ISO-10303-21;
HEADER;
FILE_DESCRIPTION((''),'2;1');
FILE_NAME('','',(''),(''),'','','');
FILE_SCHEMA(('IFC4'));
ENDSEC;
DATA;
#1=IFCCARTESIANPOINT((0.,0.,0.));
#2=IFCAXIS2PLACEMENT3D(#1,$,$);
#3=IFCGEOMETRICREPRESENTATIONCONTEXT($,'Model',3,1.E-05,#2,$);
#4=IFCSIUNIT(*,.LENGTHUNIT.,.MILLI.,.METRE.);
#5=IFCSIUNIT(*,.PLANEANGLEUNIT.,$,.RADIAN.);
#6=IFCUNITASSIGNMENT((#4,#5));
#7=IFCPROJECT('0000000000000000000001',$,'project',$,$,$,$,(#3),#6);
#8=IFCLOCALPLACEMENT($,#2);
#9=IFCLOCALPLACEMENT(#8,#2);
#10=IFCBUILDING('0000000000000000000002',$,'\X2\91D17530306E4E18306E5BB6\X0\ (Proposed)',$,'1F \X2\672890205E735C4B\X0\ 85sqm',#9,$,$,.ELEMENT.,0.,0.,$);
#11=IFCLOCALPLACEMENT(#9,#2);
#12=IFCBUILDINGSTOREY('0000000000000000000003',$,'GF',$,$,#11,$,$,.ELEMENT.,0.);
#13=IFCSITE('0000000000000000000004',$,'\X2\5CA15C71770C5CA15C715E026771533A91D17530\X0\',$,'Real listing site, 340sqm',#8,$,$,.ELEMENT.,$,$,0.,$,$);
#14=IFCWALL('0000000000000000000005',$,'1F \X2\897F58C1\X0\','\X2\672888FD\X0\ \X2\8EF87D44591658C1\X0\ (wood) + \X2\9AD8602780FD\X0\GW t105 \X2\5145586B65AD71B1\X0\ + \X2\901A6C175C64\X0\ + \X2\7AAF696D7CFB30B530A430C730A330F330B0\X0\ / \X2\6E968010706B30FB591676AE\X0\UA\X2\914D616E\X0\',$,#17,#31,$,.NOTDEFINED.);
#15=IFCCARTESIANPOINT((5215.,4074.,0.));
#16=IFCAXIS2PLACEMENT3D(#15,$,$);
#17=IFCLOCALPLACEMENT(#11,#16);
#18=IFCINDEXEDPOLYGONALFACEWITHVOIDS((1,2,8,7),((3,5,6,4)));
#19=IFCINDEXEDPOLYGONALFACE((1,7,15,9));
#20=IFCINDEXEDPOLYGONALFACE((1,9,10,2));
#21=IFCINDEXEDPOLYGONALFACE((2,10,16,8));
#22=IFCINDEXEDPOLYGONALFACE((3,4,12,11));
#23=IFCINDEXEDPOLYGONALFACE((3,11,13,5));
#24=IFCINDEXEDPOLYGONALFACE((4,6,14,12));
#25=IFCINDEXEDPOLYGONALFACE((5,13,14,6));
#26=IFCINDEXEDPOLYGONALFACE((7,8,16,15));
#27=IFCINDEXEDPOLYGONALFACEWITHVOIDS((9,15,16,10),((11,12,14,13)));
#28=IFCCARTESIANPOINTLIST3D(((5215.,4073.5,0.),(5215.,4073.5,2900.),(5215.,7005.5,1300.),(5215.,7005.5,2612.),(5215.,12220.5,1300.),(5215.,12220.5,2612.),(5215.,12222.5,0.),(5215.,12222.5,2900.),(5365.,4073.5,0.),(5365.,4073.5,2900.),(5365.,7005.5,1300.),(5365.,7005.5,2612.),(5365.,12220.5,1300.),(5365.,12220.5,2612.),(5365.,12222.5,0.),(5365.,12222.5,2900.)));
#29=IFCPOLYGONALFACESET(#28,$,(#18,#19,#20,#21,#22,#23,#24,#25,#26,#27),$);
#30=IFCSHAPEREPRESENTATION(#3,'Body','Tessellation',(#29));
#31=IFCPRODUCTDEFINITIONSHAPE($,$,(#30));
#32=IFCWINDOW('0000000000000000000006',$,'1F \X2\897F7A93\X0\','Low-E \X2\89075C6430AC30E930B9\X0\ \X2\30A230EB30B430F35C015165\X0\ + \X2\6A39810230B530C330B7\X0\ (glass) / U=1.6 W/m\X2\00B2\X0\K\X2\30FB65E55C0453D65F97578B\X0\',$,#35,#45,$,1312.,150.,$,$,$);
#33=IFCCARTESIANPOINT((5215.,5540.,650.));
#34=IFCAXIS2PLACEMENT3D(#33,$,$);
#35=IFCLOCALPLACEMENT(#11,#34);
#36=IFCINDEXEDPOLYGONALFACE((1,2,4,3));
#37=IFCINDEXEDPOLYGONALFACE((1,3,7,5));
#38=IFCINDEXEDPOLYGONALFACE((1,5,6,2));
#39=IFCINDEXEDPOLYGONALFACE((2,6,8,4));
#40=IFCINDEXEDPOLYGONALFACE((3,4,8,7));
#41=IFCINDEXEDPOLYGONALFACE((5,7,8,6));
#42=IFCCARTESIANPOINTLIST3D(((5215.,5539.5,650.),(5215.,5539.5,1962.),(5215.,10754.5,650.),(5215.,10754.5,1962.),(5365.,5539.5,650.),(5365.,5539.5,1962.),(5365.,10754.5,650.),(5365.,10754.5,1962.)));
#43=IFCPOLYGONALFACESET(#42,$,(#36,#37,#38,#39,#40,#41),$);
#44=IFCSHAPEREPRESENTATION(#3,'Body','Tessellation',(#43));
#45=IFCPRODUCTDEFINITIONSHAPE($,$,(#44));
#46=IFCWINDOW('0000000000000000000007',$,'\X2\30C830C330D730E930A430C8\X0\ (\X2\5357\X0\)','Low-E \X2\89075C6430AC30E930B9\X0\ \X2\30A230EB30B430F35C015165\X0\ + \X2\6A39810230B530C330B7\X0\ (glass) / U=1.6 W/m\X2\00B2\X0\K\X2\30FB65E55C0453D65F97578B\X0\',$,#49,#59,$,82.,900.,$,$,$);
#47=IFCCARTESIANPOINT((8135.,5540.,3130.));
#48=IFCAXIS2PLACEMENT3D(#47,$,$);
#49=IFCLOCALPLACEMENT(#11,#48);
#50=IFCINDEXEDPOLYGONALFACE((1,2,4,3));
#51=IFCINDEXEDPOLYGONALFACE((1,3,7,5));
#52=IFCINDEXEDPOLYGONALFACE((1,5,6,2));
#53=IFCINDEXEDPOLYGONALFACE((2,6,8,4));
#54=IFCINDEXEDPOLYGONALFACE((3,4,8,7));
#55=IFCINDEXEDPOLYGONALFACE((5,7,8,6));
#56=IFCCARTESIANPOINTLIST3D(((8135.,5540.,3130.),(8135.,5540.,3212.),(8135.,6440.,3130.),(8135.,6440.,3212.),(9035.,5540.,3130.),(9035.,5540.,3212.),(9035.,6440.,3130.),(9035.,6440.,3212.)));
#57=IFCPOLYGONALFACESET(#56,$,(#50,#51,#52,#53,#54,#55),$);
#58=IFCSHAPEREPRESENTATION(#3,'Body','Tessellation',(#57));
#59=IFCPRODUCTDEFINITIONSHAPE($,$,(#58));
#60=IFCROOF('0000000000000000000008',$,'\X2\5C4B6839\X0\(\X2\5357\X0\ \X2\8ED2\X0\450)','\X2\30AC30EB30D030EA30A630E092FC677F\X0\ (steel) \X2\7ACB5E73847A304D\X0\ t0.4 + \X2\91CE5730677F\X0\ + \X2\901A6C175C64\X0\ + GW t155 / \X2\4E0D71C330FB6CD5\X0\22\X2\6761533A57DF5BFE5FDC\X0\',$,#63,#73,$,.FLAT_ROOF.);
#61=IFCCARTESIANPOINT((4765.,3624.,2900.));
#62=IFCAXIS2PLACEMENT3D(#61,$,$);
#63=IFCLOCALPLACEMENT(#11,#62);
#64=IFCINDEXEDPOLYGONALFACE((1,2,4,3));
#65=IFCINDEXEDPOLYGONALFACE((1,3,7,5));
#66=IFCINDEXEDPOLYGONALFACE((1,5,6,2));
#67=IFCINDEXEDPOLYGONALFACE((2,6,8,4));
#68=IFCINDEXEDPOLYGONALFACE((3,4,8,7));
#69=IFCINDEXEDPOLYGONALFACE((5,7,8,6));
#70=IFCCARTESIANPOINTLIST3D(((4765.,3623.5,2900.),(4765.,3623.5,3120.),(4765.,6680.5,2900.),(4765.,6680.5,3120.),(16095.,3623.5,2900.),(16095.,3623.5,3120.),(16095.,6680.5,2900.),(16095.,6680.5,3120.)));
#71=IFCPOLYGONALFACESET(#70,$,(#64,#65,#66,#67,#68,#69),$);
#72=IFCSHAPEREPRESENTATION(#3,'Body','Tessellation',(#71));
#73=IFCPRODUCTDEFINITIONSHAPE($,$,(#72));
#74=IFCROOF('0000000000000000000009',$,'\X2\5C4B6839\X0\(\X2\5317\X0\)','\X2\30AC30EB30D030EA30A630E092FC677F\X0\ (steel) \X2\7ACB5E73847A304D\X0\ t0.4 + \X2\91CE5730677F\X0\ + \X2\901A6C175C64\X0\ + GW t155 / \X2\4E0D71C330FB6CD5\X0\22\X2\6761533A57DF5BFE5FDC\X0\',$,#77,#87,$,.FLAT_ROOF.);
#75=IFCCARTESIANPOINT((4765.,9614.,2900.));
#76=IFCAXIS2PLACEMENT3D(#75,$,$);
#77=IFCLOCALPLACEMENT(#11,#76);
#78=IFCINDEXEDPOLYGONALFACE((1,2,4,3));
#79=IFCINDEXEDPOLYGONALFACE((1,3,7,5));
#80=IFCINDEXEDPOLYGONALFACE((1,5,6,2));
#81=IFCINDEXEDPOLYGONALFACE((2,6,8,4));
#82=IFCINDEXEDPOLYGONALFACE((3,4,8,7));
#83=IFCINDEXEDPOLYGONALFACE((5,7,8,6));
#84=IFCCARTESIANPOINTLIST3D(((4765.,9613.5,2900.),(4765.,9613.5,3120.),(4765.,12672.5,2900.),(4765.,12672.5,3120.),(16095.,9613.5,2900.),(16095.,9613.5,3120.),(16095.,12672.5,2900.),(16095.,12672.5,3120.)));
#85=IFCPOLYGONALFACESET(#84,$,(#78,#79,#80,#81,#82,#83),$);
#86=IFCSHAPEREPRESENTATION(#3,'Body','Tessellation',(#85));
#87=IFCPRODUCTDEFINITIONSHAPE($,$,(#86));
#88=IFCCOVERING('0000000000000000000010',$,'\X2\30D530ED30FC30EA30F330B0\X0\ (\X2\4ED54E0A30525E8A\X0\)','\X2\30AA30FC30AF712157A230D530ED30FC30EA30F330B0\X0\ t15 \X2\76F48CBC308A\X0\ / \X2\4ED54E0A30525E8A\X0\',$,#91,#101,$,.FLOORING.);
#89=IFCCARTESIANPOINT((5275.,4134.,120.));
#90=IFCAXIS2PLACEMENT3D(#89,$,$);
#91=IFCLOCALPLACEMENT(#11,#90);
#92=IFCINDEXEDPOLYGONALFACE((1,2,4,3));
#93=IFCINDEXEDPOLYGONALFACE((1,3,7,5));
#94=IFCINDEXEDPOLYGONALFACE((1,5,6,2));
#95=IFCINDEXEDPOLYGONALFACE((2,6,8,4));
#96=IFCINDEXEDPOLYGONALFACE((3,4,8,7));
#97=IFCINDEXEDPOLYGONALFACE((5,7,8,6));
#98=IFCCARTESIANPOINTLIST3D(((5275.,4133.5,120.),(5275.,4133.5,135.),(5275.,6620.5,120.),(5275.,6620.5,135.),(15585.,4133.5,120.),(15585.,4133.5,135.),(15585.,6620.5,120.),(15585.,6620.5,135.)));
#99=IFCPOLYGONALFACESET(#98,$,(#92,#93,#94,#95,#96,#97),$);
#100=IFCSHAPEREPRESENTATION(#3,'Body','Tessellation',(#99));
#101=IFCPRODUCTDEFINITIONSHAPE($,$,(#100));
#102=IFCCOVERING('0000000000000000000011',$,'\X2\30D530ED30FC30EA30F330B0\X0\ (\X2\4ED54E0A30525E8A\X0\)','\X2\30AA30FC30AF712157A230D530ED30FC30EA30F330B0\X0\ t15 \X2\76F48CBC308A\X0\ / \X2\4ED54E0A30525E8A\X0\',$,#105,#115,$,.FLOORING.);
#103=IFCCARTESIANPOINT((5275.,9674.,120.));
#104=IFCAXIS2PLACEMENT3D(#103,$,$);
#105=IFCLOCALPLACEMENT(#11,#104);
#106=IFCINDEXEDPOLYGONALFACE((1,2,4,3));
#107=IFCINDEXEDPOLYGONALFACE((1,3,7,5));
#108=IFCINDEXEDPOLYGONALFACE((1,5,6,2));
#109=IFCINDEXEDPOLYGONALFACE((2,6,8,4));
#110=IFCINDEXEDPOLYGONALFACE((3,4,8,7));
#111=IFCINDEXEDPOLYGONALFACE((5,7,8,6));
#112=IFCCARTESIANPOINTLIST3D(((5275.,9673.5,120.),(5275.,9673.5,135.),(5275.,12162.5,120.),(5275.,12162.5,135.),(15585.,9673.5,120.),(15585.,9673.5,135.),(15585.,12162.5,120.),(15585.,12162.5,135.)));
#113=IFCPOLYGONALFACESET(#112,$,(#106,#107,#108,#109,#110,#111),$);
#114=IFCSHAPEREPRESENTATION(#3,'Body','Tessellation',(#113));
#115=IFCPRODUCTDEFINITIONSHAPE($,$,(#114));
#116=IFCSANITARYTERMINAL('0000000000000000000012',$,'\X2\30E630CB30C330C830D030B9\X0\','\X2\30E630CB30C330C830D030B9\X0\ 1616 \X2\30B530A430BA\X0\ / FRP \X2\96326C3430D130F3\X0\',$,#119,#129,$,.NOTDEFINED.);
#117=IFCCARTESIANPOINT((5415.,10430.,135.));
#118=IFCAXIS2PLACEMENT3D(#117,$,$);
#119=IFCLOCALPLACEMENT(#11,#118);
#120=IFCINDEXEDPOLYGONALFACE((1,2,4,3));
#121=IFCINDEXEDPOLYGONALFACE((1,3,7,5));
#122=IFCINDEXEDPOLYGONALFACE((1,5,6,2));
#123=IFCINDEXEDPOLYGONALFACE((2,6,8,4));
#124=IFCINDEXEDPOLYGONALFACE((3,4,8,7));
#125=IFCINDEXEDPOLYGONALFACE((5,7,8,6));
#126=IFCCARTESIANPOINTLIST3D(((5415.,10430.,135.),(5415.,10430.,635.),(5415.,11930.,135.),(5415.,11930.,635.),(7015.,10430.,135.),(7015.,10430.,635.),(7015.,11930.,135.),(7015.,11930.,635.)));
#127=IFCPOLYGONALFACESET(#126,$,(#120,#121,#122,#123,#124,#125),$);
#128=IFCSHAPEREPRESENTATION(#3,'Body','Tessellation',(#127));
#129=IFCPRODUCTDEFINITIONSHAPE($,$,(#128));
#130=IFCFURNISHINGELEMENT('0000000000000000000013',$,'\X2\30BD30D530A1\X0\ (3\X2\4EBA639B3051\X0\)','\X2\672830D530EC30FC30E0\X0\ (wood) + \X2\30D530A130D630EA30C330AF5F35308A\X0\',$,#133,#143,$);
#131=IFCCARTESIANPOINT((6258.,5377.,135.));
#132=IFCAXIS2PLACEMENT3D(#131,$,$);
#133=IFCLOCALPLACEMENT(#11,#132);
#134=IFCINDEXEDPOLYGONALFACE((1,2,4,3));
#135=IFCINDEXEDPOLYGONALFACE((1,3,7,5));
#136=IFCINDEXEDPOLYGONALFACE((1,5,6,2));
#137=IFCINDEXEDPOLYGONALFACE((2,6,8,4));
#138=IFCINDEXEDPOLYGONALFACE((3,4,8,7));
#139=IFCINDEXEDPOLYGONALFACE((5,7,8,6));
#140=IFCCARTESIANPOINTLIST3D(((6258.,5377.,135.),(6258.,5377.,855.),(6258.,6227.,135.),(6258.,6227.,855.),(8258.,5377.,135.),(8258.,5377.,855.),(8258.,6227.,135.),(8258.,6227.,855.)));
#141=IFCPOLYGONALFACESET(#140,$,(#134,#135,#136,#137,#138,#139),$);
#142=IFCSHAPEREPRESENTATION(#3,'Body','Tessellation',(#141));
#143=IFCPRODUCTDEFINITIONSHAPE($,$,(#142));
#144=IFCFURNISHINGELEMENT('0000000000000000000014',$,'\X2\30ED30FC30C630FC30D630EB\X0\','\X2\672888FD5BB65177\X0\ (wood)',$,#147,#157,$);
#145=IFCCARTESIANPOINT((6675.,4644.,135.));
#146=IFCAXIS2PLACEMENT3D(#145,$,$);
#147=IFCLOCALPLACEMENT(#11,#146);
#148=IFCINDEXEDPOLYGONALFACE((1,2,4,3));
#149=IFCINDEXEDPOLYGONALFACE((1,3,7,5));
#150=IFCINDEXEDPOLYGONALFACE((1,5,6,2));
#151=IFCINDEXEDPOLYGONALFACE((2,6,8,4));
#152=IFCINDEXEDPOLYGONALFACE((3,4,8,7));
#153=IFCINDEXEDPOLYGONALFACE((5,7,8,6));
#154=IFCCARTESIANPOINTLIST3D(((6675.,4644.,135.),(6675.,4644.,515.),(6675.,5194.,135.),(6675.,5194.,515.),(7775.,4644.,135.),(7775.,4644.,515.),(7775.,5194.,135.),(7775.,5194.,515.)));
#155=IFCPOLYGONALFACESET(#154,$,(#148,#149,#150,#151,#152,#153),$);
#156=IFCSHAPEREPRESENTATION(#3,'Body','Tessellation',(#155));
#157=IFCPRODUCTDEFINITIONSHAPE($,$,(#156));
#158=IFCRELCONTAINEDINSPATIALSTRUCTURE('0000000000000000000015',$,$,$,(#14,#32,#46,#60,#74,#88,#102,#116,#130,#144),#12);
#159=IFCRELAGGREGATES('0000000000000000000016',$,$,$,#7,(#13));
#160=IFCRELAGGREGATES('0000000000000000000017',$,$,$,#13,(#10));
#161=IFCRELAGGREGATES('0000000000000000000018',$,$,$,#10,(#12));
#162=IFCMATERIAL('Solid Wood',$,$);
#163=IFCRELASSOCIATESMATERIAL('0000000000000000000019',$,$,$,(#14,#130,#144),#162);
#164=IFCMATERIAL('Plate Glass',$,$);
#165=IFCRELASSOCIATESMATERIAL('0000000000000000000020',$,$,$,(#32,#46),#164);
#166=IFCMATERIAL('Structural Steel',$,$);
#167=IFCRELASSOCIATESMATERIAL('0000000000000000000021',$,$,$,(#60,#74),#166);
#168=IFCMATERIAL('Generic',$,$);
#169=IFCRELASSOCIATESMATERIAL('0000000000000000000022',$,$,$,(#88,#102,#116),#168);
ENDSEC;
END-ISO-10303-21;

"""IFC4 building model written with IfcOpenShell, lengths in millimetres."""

from ifc_helpers import new_model, si_unit, frame, frame_2d, origin, place, context, project, spatial, rectangle, extrude, material, element, fill, save


model = new_model("IFC4")

# Units and contexts
model_context = context("Model", 3, precision=1e-05, world=origin())
ifc_project = project(units=[si_unit("LENGTHUNIT", "METRE", prefix="MILLI"), si_unit("PLANEANGLEUNIT", "RADIAN")], contexts=[model_context])

# Site, building, storey
site_placement = place(None, origin())
site = spatial("IfcSite", under=ifc_project, at=site_placement, Name="岡山県岡山市東区金田", ObjectType="Real listing site, 340sqm", CompositionType="ELEMENT", RefElevation=0.0)
building_placement = place(site_placement, origin())
building = spatial("IfcBuilding", under=site, at=building_placement, Name="金田の丘の家 (Proposed)", ObjectType="1F 木造平屋 85sqm", CompositionType="ELEMENT", ElevationOfRefHeight=0.0, ElevationOfTerrain=0.0)
storey_placement = place(building_placement, origin())
storey = spatial("IfcBuildingStorey", under=building, at=storey_placement, Name="GF", CompositionType="ELEMENT", Elevation=0.0)

# Shared definitions
ifc_material_1 = material(Name="Solid Wood")

# Shared definitions
ifc_material_2 = material(Name="Plate Glass")

# Wall, opening, window
wall_1_placement = place(storey_placement, frame((5215.0, 4074.0, 0.0)))
wall_1 = element("IfcWall", 1, at=wall_1_placement, inside=storey, material=ifc_material_1, Name="1F 西壁", Description="木製 軸組外壁 (wood) + 高性能GW t105 充填断熱 + 通気層 + 窯業系サイディング / 準耐火・外皮UA配慮", PredefinedType="NOTDEFINED", context=model_context, shape_type="SweptSolid", body=[
    extrude(rectangle(XDim=150.0, YDim=8149.0, at=frame_2d((75.0, 4074.0))), frame((5215.0, 4074.0, 0.0)), (0.0, 0.0, 1.0), 2900.0),
])
opening_1_placement = place(storey_placement, frame((5215.0, 5540.0, 650.0)))
opening_1 = element("IfcOpeningElement", 2, at=opening_1_placement, cuts=wall_1, PredefinedType="NOTDEFINED", context=model_context, shape_type="SweptSolid", body=[
    extrude(rectangle(XDim=150.0, YDim=5215.0, at=frame_2d((75.0, 2607.0))), frame((5215.0, 5540.0, 650.0)), (0.0, 0.0, 1.0), 1312.0),
])
window_1_placement = place(storey_placement, frame((5215.0, 5540.0, 650.0)))
window_1 = element("IfcWindow", 3, at=window_1_placement, inside=storey, material=ifc_material_2, Name="1F 西窓", Description="Low-E 複層ガラス アルゴン封入 + 樹脂サッシ (glass) / U=1.6 W/m²K・日射取得型", OverallHeight=1312.0, OverallWidth=150.0, context=model_context, shape_type="SweptSolid", body=[
    extrude(rectangle(XDim=150.0, YDim=5215.0, at=frame_2d((75.0, 2607.0))), frame((5215.0, 5540.0, 650.0)), (0.0, 0.0, 1.0), 1312.0),
])
fill(opening_1, window_1)

# Window
window_2_placement = place(storey_placement, frame((8135.0, 5540.0, 3130.0)))
element("IfcWindow", 4, at=window_2_placement, inside=storey, material=ifc_material_2, Name="トップライト (南)", Description="Low-E 複層ガラス アルゴン封入 + 樹脂サッシ (glass) / U=1.6 W/m²K・日射取得型", OverallHeight=82.0, OverallWidth=900.0, context=model_context, shape_type="SweptSolid", body=[
    extrude(rectangle(XDim=900.0, YDim=900.0, at=frame_2d((450.0, 450.0))), frame((8135.0, 5540.0, 3130.0)), (0.0, 0.0, 1.0), 82.0),
])

# Roofs
ifc_material_3 = material(Name="Structural Steel")
roof_1_placement = place(storey_placement, frame((4765.0, 3624.0, 2900.0)))
element("IfcRoof", 5, at=roof_1_placement, inside=storey, material=ifc_material_3, Name="屋根(南 軒450)", Description="ガルバリウム鋼板 (steel) 立平葺き t0.4 + 野地板 + 通気層 + GW t155 / 不燃・法22条区域対応", PredefinedType="FLAT_ROOF", context=model_context, shape_type="SweptSolid", body=[
    extrude(rectangle(XDim=11330.0, YDim=3057.0, at=frame_2d((5665.0, 1528.0))), frame((4765.0, 3624.0, 2900.0)), (0.0, 0.0, 1.0), 220.0),
])
roof_2_placement = place(storey_placement, frame((4765.0, 9614.0, 2900.0)))
element("IfcRoof", 6, at=roof_2_placement, inside=storey, material=ifc_material_3, Name="屋根(北)", Description="ガルバリウム鋼板 (steel) 立平葺き t0.4 + 野地板 + 通気層 + GW t155 / 不燃・法22条区域対応", PredefinedType="FLAT_ROOF", context=model_context, shape_type="SweptSolid", body=[
    extrude(rectangle(XDim=11330.0, YDim=3059.0, at=frame_2d((5665.0, 1529.0))), frame((4765.0, 9614.0, 2900.0)), (0.0, 0.0, 1.0), 220.0),
])

# Coverings
ifc_material_4 = material(Name="Generic")
covering_1_placement = place(storey_placement, frame((5275.0, 4134.0, 120.0)))
element("IfcCovering", 7, at=covering_1_placement, inside=storey, material=ifc_material_4, Name="フローリング (仕上げ床)", Description="オーク無垢フローリング t15 直貼り / 仕上げ床", PredefinedType="FLOORING", context=model_context, shape_type="SweptSolid", body=[
    extrude(rectangle(XDim=10310.0, YDim=2487.0, at=frame_2d((5155.0, 1243.0))), frame((5275.0, 4134.0, 120.0)), (0.0, 0.0, 1.0), 15.0),
])
covering_2_placement = place(storey_placement, frame((5275.0, 9674.0, 120.0)))
element("IfcCovering", 8, at=covering_2_placement, inside=storey, material=ifc_material_4, Name="フローリング (仕上げ床)", Description="オーク無垢フローリング t15 直貼り / 仕上げ床", PredefinedType="FLOORING", context=model_context, shape_type="SweptSolid", body=[
    extrude(rectangle(XDim=10310.0, YDim=2489.0, at=frame_2d((5155.0, 1244.0))), frame((5275.0, 9674.0, 120.0)), (0.0, 0.0, 1.0), 15.0),
])

# Sanitary terminal
sanitary_terminal_placement = place(storey_placement, frame((5415.0, 10430.0, 135.0)))
element("IfcSanitaryTerminal", 9, at=sanitary_terminal_placement, inside=storey, material=ifc_material_4, Name="ユニットバス", Description="ユニットバス 1616 サイズ / FRP 防水パン", PredefinedType="NOTDEFINED", context=model_context, shape_type="SweptSolid", body=[
    extrude(rectangle(XDim=1600.0, YDim=1500.0, at=frame_2d((800.0, 750.0))), frame((5415.0, 10430.0, 135.0)), (0.0, 0.0, 1.0), 500.0),
])

# Furnishing elements
furnishing_1_placement = place(storey_placement, frame((6258.0, 5377.0, 135.0)))
element("IfcFurnishingElement", 10, at=furnishing_1_placement, inside=storey, material=ifc_material_1, Name="ソファ (3人掛け)", Description="木フレーム (wood) + ファブリック張り", context=model_context, shape_type="SweptSolid", body=[
    extrude(rectangle(XDim=2000.0, YDim=850.0, at=frame_2d((1000.0, 425.0))), frame((6258.0, 5377.0, 135.0)), (0.0, 0.0, 1.0), 720.0),
])
furnishing_2_placement = place(storey_placement, frame((6675.0, 4644.0, 135.0)))
element("IfcFurnishingElement", 11, at=furnishing_2_placement, inside=storey, material=ifc_material_1, Name="ローテーブル", Description="木製家具 (wood)", context=model_context, shape_type="SweptSolid", body=[
    extrude(rectangle(XDim=1100.0, YDim=550.0, at=frame_2d((550.0, 275.0))), frame((6675.0, 4644.0, 135.0)), (0.0, 0.0, 1.0), 380.0),
])

save(model, "model.ifc")
